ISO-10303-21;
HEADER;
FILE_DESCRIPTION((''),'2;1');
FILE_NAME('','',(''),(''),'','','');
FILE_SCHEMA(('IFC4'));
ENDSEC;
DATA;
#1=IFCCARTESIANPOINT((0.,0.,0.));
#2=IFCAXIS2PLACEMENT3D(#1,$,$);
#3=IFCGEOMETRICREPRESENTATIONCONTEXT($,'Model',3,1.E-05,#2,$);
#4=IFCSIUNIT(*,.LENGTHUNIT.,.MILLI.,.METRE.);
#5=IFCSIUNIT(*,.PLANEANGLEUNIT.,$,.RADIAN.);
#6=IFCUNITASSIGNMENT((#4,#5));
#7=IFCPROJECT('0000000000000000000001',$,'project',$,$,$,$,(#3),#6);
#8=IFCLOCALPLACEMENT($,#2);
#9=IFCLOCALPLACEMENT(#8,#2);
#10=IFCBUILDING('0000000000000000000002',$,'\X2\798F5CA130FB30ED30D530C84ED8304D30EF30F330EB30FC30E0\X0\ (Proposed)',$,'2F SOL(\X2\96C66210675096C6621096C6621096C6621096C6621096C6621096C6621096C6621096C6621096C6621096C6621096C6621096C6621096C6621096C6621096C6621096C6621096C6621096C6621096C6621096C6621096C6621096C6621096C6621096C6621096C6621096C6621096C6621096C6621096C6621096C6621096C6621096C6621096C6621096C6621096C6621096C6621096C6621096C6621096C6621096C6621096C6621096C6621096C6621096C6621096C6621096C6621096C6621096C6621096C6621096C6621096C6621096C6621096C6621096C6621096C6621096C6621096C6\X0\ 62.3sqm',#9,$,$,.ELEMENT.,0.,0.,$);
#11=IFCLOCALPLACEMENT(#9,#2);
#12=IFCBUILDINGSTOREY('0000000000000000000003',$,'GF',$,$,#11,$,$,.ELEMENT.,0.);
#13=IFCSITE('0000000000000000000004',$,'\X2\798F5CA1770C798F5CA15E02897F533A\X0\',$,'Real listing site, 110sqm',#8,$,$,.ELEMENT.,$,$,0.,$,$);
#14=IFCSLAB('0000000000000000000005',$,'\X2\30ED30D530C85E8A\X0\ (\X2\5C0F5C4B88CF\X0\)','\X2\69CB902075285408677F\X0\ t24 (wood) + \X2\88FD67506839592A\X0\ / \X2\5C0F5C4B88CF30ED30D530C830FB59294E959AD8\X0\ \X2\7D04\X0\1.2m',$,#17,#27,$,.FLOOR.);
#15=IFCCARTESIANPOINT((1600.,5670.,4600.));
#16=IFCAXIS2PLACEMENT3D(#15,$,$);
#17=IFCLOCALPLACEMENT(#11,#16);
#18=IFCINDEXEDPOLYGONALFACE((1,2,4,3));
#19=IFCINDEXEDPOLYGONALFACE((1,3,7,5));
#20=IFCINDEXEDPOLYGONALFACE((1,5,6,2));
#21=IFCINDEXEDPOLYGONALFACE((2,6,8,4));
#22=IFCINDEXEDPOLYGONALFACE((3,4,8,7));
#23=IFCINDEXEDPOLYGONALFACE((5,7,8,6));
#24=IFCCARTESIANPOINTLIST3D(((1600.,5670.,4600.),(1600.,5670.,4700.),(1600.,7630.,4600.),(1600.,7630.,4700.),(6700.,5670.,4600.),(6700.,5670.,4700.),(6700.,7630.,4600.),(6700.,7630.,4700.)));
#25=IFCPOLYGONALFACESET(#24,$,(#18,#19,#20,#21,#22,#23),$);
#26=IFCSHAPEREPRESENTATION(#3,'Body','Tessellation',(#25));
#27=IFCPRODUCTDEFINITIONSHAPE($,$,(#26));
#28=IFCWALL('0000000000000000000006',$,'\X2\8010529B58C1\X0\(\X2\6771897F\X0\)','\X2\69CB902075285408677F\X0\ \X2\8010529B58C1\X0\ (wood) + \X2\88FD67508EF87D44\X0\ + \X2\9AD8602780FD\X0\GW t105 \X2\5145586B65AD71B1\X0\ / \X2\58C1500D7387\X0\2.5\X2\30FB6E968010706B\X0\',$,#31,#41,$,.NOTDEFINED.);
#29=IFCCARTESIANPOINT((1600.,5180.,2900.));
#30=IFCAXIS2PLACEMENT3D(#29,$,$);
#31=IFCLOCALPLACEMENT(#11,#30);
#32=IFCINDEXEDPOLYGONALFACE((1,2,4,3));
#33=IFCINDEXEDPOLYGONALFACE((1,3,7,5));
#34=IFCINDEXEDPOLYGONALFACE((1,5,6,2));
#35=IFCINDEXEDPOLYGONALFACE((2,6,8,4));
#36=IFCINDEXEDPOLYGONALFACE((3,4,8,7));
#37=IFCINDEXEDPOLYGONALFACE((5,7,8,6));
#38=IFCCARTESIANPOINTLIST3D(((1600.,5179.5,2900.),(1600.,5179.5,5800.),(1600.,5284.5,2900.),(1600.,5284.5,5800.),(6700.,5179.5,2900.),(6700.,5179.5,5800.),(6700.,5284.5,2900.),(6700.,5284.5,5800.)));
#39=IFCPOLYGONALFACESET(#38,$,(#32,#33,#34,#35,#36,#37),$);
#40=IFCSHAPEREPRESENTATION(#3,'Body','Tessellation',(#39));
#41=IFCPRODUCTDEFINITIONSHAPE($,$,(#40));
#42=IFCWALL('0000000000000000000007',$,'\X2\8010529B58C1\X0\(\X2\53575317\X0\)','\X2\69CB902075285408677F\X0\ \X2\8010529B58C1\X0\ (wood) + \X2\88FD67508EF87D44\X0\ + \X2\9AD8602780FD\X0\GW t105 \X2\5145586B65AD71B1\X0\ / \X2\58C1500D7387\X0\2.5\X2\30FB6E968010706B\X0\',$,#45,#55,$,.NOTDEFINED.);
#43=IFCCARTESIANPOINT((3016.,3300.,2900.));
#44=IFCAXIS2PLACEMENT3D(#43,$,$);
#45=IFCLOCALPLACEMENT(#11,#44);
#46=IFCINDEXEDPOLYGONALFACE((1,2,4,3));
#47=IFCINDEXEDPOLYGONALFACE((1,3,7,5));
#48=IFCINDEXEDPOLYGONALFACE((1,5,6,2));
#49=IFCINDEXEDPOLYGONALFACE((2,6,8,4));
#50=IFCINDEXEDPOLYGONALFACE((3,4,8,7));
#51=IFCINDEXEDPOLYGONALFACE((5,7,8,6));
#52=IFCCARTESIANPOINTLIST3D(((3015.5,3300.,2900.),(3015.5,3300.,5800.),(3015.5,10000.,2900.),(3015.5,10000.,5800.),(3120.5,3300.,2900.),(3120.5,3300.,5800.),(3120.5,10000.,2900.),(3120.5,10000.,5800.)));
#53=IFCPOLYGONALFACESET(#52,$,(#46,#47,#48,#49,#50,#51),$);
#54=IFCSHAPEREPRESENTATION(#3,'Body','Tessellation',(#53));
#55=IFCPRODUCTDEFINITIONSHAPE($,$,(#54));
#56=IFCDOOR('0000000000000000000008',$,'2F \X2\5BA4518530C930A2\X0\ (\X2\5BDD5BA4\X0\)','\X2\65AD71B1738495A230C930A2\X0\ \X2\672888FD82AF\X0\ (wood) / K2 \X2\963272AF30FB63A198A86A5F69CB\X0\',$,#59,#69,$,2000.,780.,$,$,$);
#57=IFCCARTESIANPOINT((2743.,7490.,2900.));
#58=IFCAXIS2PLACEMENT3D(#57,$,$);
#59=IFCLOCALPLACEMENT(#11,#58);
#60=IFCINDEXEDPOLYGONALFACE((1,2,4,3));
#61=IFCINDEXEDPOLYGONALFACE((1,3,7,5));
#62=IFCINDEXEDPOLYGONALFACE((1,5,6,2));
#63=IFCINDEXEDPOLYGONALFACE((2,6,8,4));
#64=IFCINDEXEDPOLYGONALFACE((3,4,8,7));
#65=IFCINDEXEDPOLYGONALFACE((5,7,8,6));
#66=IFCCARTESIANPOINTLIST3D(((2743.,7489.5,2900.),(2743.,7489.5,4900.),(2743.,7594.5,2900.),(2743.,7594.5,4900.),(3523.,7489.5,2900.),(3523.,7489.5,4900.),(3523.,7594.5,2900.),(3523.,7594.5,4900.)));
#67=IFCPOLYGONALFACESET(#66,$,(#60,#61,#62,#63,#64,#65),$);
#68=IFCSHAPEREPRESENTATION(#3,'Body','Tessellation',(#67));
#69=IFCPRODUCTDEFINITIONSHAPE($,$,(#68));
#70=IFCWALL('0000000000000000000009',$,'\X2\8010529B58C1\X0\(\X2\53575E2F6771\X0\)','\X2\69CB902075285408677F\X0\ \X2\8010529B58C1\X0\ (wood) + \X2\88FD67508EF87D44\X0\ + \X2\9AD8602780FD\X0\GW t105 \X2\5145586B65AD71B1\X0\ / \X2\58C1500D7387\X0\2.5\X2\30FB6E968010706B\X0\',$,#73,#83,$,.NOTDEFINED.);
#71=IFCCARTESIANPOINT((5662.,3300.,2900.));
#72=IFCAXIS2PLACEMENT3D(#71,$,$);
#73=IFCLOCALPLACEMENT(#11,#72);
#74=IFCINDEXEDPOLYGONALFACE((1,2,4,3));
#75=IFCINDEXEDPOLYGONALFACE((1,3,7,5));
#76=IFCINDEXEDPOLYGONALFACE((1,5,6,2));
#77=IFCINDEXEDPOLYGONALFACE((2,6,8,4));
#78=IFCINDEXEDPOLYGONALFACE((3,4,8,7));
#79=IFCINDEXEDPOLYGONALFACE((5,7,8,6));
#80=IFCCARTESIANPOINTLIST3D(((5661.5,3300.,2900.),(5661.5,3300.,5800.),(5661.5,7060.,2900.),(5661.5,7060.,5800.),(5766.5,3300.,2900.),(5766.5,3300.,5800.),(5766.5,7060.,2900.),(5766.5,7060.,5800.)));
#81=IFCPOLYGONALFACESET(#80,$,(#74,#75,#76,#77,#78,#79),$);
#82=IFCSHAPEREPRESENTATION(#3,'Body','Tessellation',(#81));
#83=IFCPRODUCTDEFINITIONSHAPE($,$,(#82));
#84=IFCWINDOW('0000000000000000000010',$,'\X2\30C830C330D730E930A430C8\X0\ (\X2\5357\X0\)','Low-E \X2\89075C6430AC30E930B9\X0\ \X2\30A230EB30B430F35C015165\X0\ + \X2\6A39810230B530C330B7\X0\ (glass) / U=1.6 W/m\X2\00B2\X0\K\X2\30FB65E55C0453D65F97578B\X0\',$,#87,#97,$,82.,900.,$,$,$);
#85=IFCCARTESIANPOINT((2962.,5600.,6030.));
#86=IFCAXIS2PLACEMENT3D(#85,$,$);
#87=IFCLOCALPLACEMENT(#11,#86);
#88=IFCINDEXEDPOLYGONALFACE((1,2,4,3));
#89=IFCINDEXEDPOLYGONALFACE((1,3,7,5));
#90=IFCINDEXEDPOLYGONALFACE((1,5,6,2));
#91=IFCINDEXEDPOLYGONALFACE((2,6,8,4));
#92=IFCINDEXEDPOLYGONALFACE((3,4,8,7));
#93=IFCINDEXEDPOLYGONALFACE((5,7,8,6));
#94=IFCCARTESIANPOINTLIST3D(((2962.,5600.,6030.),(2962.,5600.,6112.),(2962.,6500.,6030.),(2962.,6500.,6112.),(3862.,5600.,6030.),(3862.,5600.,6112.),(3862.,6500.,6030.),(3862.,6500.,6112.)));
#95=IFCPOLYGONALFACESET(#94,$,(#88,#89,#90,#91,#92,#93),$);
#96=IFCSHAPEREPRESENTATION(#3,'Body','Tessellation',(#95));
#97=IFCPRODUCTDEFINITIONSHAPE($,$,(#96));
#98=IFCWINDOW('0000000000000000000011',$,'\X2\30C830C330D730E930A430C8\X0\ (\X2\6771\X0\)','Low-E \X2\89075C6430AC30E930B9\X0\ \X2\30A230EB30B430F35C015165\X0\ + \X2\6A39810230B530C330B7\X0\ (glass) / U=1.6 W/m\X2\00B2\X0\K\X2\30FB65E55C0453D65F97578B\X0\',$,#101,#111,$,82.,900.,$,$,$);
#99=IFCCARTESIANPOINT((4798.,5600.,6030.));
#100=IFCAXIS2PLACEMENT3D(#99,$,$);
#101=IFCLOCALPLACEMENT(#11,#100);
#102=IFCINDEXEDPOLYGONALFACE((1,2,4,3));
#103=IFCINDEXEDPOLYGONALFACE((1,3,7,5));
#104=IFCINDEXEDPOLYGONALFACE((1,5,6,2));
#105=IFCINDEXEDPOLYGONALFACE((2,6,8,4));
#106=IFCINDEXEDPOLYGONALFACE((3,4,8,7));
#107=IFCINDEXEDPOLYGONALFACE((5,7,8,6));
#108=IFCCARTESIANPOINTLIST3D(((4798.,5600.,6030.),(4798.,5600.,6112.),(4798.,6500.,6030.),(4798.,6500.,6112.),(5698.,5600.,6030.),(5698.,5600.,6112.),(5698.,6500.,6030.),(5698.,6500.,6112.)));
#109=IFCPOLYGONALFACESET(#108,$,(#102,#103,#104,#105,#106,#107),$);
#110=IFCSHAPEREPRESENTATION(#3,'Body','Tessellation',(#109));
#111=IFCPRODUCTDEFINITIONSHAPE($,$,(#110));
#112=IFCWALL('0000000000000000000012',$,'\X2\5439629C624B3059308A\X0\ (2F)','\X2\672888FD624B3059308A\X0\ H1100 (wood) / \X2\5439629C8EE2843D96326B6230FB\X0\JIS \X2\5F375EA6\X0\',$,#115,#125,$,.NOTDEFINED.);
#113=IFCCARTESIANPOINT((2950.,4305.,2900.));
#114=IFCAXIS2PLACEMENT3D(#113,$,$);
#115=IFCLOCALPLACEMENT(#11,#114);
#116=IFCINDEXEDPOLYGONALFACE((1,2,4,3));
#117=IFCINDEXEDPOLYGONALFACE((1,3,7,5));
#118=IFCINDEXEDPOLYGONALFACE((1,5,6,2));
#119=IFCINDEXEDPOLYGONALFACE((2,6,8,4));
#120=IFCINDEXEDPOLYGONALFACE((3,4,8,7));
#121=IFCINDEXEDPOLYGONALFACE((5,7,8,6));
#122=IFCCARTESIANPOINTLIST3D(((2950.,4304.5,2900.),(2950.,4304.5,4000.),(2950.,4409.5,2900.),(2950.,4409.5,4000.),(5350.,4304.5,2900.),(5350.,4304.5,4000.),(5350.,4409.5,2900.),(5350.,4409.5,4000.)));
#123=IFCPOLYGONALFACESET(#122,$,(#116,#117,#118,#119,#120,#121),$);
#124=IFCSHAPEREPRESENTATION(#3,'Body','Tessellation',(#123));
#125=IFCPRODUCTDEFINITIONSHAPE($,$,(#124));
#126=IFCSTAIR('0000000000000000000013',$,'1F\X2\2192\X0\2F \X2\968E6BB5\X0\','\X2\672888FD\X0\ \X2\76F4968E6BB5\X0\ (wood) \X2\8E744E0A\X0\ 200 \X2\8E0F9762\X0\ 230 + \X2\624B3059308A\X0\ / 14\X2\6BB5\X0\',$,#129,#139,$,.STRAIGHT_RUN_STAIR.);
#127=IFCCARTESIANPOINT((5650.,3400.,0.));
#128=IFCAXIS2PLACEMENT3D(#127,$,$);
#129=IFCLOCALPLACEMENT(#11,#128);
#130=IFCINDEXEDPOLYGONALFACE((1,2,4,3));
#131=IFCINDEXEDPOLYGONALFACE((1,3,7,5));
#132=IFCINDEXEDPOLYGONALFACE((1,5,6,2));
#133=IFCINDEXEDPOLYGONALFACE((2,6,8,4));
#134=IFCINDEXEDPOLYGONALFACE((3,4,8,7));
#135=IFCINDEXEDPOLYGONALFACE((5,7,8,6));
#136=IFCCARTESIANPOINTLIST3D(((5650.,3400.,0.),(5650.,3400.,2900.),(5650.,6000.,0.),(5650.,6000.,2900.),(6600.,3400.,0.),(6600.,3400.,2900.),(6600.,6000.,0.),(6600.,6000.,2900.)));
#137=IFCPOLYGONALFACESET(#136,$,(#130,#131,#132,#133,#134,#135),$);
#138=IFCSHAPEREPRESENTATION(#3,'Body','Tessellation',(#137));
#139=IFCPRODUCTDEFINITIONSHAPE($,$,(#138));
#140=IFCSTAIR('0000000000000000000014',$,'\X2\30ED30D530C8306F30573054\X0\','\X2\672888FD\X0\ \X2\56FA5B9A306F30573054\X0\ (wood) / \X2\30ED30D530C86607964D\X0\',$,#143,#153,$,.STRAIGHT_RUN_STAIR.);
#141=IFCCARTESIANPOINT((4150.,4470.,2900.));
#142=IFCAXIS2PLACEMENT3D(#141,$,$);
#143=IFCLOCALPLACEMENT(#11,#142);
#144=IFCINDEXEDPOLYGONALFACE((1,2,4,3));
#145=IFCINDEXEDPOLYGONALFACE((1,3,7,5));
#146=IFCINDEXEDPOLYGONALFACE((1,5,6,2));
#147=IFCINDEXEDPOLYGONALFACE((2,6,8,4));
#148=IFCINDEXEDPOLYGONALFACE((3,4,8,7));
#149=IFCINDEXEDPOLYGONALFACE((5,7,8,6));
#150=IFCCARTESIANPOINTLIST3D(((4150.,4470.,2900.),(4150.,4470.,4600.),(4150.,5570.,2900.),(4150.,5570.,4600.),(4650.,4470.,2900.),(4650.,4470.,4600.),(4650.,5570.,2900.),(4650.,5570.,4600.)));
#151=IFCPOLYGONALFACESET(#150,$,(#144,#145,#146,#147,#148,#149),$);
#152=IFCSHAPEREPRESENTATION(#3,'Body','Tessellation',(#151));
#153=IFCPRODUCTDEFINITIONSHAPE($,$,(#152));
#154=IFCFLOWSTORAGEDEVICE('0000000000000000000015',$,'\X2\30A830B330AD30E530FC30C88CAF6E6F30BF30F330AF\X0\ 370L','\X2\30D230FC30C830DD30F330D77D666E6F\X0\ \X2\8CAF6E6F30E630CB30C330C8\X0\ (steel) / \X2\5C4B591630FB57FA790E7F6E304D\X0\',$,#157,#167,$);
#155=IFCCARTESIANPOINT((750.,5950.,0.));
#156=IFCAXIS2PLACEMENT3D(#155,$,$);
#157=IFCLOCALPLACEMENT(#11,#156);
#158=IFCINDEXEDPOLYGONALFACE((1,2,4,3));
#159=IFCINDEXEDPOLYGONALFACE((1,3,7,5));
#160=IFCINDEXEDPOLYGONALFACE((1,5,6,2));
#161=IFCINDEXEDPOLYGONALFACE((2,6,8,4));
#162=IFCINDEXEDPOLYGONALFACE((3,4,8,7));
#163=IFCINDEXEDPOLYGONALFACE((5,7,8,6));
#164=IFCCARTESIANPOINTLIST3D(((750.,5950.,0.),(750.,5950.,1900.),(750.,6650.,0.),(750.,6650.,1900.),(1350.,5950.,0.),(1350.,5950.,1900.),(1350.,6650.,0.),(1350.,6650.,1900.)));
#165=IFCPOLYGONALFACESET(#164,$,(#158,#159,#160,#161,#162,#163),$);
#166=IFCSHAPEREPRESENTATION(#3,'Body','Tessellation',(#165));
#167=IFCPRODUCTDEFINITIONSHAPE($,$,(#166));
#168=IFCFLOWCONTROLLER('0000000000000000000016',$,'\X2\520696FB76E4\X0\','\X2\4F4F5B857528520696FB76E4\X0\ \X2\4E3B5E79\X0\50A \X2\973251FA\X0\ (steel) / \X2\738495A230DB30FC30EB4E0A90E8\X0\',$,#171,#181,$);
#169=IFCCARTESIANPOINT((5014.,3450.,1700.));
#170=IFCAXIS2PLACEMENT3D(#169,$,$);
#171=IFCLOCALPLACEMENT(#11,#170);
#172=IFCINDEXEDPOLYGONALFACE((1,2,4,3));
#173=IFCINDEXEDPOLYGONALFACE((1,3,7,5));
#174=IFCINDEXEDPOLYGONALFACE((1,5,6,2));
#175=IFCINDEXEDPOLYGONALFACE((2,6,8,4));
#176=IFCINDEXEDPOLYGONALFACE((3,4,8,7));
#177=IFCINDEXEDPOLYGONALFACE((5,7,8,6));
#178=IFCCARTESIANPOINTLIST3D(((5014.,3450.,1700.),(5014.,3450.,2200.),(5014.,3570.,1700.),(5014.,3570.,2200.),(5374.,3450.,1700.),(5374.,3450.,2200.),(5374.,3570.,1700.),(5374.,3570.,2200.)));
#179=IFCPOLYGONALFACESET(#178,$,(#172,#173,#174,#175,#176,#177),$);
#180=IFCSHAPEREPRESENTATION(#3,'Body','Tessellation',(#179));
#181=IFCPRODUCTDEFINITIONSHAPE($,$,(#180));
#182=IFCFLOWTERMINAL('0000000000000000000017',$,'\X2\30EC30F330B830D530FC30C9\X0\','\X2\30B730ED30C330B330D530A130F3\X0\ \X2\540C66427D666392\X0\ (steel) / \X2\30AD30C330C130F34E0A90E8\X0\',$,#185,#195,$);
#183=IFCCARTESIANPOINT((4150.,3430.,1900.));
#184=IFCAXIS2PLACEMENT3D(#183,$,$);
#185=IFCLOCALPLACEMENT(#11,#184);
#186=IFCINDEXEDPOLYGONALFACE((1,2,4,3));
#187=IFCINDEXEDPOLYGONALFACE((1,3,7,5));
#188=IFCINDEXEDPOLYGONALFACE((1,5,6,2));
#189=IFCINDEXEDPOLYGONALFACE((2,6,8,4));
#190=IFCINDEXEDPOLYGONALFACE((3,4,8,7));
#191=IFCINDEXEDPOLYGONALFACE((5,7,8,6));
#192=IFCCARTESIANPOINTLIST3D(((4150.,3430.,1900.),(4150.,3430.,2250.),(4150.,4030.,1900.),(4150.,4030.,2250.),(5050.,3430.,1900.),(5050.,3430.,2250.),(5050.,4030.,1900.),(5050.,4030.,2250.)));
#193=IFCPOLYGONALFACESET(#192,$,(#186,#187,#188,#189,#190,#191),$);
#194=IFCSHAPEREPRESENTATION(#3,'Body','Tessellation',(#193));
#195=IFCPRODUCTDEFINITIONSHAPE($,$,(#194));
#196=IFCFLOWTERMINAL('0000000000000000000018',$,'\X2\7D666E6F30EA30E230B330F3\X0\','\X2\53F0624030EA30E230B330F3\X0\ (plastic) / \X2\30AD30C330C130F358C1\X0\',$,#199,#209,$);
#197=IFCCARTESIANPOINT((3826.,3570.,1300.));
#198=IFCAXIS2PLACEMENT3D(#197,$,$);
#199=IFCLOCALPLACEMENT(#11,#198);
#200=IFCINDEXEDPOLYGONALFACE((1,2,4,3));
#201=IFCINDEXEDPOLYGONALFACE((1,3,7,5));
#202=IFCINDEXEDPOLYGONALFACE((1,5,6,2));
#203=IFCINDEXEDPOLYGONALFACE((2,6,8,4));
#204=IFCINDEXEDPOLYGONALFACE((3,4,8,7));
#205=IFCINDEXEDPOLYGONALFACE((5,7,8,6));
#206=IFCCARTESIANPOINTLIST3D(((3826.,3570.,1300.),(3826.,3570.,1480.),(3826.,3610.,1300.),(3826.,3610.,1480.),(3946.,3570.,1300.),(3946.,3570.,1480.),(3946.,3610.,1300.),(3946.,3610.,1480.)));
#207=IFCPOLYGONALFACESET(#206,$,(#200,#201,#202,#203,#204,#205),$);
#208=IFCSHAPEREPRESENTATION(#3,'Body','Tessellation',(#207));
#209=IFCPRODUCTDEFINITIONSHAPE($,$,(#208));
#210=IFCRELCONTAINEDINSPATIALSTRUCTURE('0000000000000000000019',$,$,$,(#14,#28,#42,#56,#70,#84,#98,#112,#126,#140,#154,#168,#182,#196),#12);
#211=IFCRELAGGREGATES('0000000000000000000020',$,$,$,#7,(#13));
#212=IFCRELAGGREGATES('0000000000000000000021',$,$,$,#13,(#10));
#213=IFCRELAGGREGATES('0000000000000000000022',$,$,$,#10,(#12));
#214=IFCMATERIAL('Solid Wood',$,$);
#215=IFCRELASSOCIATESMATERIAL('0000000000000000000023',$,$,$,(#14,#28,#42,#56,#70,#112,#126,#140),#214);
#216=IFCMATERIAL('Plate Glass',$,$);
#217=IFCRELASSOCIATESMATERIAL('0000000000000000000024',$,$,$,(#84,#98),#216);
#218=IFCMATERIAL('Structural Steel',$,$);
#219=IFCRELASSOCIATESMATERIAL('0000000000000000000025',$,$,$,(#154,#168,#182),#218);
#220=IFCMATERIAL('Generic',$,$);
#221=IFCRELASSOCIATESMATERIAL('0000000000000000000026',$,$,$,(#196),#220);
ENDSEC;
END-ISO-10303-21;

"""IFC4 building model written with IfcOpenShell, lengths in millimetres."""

from ifc_helpers import new_model, si_unit, frame, frame_2d, origin, place, context, project, spatial, rectangle, extrude, material, element, fill, save


model = new_model("IFC4")

# Units and contexts
model_context = context("Model", 3, precision=1e-05, world=origin())
ifc_project = project(units=[si_unit("LENGTHUNIT", "METRE", prefix="MILLI"), si_unit("PLANEANGLEUNIT", "RADIAN")], contexts=[model_context])

# Site, building, storey
site_placement = place(None, origin())
site = spatial("IfcSite", under=ifc_project, at=site_placement, Name="福岡県福岡市西区", ObjectType="Real listing site, 110sqm", CompositionType="ELEMENT", RefElevation=0.0)
building_placement = place(site_placement, origin())
building = spatial("IfcBuilding", under=site, at=building_placement, Name="福岡・ロフト付きワンルーム (Proposed)", ObjectType="2F SOL(集成材集成集成集成集成集成集成集成集成集成集成集成集成集成集成集成集成集成集成集成集成集成集成集成集成集成集成集成集成集成集成集成集成集成集成集成集成集成集成集成集成集成集成集成集成集成集成集成集成集成集成集成集成集成集成集成集成集 62.3sqm", CompositionType="ELEMENT", ElevationOfRefHeight=0.0, ElevationOfTerrain=0.0)
storey_placement = place(building_placement, origin())
storey = spatial("IfcBuildingStorey", under=building, at=storey_placement, Name="GF", CompositionType="ELEMENT", Elevation=0.0)

# Shared definitions
ifc_material_1 = material(Name="Solid Wood")

# Slab
slab_placement = place(storey_placement, frame((1600.0, 5670.0, 4600.0)))
element("IfcSlab", 1, at=slab_placement, inside=storey, material=ifc_material_1, Name="ロフト床 (小屋裏)", Description="構造用合板 t24 (wood) + 製材根太 / 小屋裏ロフト・天井高 約1.2m", PredefinedType="FLOOR", context=model_context, shape_type="SweptSolid", body=[
    extrude(rectangle(XDim=5100.0, YDim=1960.0, at=frame_2d((2550.0, 980.0))), frame((1600.0, 5670.0, 4600.0)), (0.0, 0.0, 1.0), 100.0),
])

# Wall
wall_1_placement = place(storey_placement, frame((1600.0, 5180.0, 2900.0)))
element("IfcWall", 2, at=wall_1_placement, inside=storey, material=ifc_material_1, Name="耐力壁(東西)", Description="構造用合板 耐力壁 (wood) + 製材軸組 + 高性能GW t105 充填断熱 / 壁倍率2.5・準耐火", PredefinedType="NOTDEFINED", context=model_context, shape_type="SweptSolid", body=[
    extrude(rectangle(XDim=5100.0, YDim=105.0, at=frame_2d((2550.0, 52.0))), frame((1600.0, 5180.0, 2900.0)), (0.0, 0.0, 1.0), 2900.0),
])

# Wall, opening, door
wall_2_placement = place(storey_placement, frame((3016.0, 3300.0, 2900.0)))
wall_2 = element("IfcWall", 3, at=wall_2_placement, inside=storey, material=ifc_material_1, Name="耐力壁(南北)", Description="構造用合板 耐力壁 (wood) + 製材軸組 + 高性能GW t105 充填断熱 / 壁倍率2.5・準耐火", PredefinedType="NOTDEFINED", context=model_context, shape_type="SweptSolid", body=[
    extrude(rectangle(XDim=105.0, YDim=6700.0, at=frame_2d((52.0, 3350.0))), frame((3016.0, 3300.0, 2900.0)), (0.0, 0.0, 1.0), 2900.0),
])
opening_placement = place(storey_placement, frame((2743.0, 7490.0, 2900.0)))
opening = element("IfcOpeningElement", 4, at=opening_placement, cuts=wall_2, PredefinedType="NOTDEFINED", context=model_context, shape_type="SweptSolid", body=[
    extrude(rectangle(XDim=780.0, YDim=105.0, at=frame_2d((390.0, 52.0))), frame((2743.0, 7490.0, 2900.0)), (0.0, 0.0, 1.0), 2000.0),
])
door_placement = place(storey_placement, frame((2743.0, 7490.0, 2900.0)))
door = element("IfcDoor", 5, at=door_placement, inside=storey, material=ifc_material_1, Name="2F 室内ドア (寝室)", Description="断熱玄関ドア 木製芯 (wood) / K2 防犯・採風機構", OverallHeight=2000.0, OverallWidth=780.0, context=model_context, shape_type="SweptSolid", body=[
    extrude(rectangle(XDim=780.0, YDim=105.0, at=frame_2d((390.0, 52.0))), frame((2743.0, 7490.0, 2900.0)), (0.0, 0.0, 1.0), 2000.0),
])
fill(opening, door)

# Wall
wall_3_placement = place(storey_placement, frame((5662.0, 3300.0, 2900.0)))
element("IfcWall", 6, at=wall_3_placement, inside=storey, material=ifc_material_1, Name="耐力壁(南帯東)", Description="構造用合板 耐力壁 (wood) + 製材軸組 + 高性能GW t105 充填断熱 / 壁倍率2.5・準耐火", PredefinedType="NOTDEFINED", context=model_context, shape_type="SweptSolid", body=[
    extrude(rectangle(XDim=105.0, YDim=3760.0, at=frame_2d((52.0, 1880.0))), frame((5662.0, 3300.0, 2900.0)), (0.0, 0.0, 1.0), 2900.0),
])

# Windows
ifc_material_2 = material(Name="Plate Glass")
window_1_placement = place(storey_placement, frame((2962.0, 5600.0, 6030.0)))
element("IfcWindow", 7, at=window_1_placement, inside=storey, material=ifc_material_2, Name="トップライト (南)", Description="Low-E 複層ガラス アルゴン封入 + 樹脂サッシ (glass) / U=1.6 W/m²K・日射取得型", OverallHeight=82.0, OverallWidth=900.0, context=model_context, shape_type="SweptSolid", body=[
    extrude(rectangle(XDim=900.0, YDim=900.0, at=frame_2d((450.0, 450.0))), frame((2962.0, 5600.0, 6030.0)), (0.0, 0.0, 1.0), 82.0),
])
window_2_placement = place(storey_placement, frame((4798.0, 5600.0, 6030.0)))
element("IfcWindow", 8, at=window_2_placement, inside=storey, material=ifc_material_2, Name="トップライト (東)", Description="Low-E 複層ガラス アルゴン封入 + 樹脂サッシ (glass) / U=1.6 W/m²K・日射取得型", OverallHeight=82.0, OverallWidth=900.0, context=model_context, shape_type="SweptSolid", body=[
    extrude(rectangle(XDim=900.0, YDim=900.0, at=frame_2d((450.0, 450.0))), frame((4798.0, 5600.0, 6030.0)), (0.0, 0.0, 1.0), 82.0),
])

# Wall
wall_4_placement = place(storey_placement, frame((2950.0, 4305.0, 2900.0)))
element("IfcWall", 9, at=wall_4_placement, inside=storey, material=ifc_material_1, Name="吹抜手すり (2F)", Description="木製手すり H1100 (wood) / 吹抜転落防止・JIS 強度", PredefinedType="NOTDEFINED", context=model_context, shape_type="SweptSolid", body=[
    extrude(rectangle(XDim=2400.0, YDim=105.0, at=frame_2d((1200.0, 52.0))), frame((2950.0, 4305.0, 2900.0)), (0.0, 0.0, 1.0), 1100.0),
])

# Stairs
stair_1_placement = place(storey_placement, frame((5650.0, 3400.0, 0.0)))
element("IfcStair", 10, at=stair_1_placement, inside=storey, material=ifc_material_1, Name="1F→2F 階段", Description="木製 直階段 (wood) 蹴上 200 踏面 230 + 手すり / 14段", PredefinedType="STRAIGHT_RUN_STAIR", context=model_context, shape_type="SweptSolid", body=[
    extrude(rectangle(XDim=950.0, YDim=2600.0, at=frame_2d((475.0, 1300.0))), frame((5650.0, 3400.0, 0.0)), (0.0, 0.0, 1.0), 2900.0),
])
stair_2_placement = place(storey_placement, frame((4150.0, 4470.0, 2900.0)))
element("IfcStair", 11, at=stair_2_placement, inside=storey, material=ifc_material_1, Name="ロフトはしご", Description="木製 固定はしご (wood) / ロフト昇降", PredefinedType="STRAIGHT_RUN_STAIR", context=model_context, shape_type="SweptSolid", body=[
    extrude(rectangle(XDim=500.0, YDim=1100.0, at=frame_2d((250.0, 550.0))), frame((4150.0, 4470.0, 2900.0)), (0.0, 0.0, 1.0), 1700.0),
])

# Flow storage device
ifc_material_3 = material(Name="Structural Steel")
flow_storage_device_placement = place(storey_placement, frame((750.0, 5950.0, 0.0)))
element("IfcFlowStorageDevice", 12, at=flow_storage_device_placement, inside=storey, material=ifc_material_3, Name="エコキュート貯湯タンク 370L", Description="ヒートポンプ給湯 貯湯ユニット (steel) / 屋外・基礎置き", context=model_context, shape_type="SweptSolid", body=[
    extrude(rectangle(XDim=600.0, YDim=700.0, at=frame_2d((300.0, 350.0))), frame((750.0, 5950.0, 0.0)), (0.0, 0.0, 1.0), 1900.0),
])

# Flow controller
flow_controller_placement = place(storey_placement, frame((5014.0, 3450.0, 1700.0)))
element("IfcFlowController", 13, at=flow_controller_placement, inside=storey, material=ifc_material_3, Name="分電盤", Description="住宅用分電盤 主幹50A 露出 (steel) / 玄関ホール上部", context=model_context, shape_type="SweptSolid", body=[
    extrude(rectangle(XDim=360.0, YDim=120.0, at=frame_2d((180.0, 60.0))), frame((5014.0, 3450.0, 1700.0)), (0.0, 0.0, 1.0), 500.0),
])

# Flow terminals
flow_terminal_1_placement = place(storey_placement, frame((4150.0, 3430.0, 1900.0)))
element("IfcFlowTerminal", 14, at=flow_terminal_1_placement, inside=storey, material=ifc_material_3, Name="レンジフード", Description="シロッコファン 同時給排 (steel) / キッチン上部", context=model_context, shape_type="SweptSolid", body=[
    extrude(rectangle(XDim=900.0, YDim=600.0, at=frame_2d((450.0, 300.0))), frame((4150.0, 3430.0, 1900.0)), (0.0, 0.0, 1.0), 350.0),
])
ifc_material_4 = material(Name="Generic")
flow_terminal_2_placement = place(storey_placement, frame((3826.0, 3570.0, 1300.0)))
element("IfcFlowTerminal", 15, at=flow_terminal_2_placement, inside=storey, material=ifc_material_4, Name="給湯リモコン", Description="台所リモコン (plastic) / キッチン壁", context=model_context, shape_type="SweptSolid", body=[
    extrude(rectangle(XDim=120.0, YDim=40.0, at=frame_2d((60.0, 20.0))), frame((3826.0, 3570.0, 1300.0)), (0.0, 0.0, 1.0), 180.0),
])

save(model, "model.ifc")
